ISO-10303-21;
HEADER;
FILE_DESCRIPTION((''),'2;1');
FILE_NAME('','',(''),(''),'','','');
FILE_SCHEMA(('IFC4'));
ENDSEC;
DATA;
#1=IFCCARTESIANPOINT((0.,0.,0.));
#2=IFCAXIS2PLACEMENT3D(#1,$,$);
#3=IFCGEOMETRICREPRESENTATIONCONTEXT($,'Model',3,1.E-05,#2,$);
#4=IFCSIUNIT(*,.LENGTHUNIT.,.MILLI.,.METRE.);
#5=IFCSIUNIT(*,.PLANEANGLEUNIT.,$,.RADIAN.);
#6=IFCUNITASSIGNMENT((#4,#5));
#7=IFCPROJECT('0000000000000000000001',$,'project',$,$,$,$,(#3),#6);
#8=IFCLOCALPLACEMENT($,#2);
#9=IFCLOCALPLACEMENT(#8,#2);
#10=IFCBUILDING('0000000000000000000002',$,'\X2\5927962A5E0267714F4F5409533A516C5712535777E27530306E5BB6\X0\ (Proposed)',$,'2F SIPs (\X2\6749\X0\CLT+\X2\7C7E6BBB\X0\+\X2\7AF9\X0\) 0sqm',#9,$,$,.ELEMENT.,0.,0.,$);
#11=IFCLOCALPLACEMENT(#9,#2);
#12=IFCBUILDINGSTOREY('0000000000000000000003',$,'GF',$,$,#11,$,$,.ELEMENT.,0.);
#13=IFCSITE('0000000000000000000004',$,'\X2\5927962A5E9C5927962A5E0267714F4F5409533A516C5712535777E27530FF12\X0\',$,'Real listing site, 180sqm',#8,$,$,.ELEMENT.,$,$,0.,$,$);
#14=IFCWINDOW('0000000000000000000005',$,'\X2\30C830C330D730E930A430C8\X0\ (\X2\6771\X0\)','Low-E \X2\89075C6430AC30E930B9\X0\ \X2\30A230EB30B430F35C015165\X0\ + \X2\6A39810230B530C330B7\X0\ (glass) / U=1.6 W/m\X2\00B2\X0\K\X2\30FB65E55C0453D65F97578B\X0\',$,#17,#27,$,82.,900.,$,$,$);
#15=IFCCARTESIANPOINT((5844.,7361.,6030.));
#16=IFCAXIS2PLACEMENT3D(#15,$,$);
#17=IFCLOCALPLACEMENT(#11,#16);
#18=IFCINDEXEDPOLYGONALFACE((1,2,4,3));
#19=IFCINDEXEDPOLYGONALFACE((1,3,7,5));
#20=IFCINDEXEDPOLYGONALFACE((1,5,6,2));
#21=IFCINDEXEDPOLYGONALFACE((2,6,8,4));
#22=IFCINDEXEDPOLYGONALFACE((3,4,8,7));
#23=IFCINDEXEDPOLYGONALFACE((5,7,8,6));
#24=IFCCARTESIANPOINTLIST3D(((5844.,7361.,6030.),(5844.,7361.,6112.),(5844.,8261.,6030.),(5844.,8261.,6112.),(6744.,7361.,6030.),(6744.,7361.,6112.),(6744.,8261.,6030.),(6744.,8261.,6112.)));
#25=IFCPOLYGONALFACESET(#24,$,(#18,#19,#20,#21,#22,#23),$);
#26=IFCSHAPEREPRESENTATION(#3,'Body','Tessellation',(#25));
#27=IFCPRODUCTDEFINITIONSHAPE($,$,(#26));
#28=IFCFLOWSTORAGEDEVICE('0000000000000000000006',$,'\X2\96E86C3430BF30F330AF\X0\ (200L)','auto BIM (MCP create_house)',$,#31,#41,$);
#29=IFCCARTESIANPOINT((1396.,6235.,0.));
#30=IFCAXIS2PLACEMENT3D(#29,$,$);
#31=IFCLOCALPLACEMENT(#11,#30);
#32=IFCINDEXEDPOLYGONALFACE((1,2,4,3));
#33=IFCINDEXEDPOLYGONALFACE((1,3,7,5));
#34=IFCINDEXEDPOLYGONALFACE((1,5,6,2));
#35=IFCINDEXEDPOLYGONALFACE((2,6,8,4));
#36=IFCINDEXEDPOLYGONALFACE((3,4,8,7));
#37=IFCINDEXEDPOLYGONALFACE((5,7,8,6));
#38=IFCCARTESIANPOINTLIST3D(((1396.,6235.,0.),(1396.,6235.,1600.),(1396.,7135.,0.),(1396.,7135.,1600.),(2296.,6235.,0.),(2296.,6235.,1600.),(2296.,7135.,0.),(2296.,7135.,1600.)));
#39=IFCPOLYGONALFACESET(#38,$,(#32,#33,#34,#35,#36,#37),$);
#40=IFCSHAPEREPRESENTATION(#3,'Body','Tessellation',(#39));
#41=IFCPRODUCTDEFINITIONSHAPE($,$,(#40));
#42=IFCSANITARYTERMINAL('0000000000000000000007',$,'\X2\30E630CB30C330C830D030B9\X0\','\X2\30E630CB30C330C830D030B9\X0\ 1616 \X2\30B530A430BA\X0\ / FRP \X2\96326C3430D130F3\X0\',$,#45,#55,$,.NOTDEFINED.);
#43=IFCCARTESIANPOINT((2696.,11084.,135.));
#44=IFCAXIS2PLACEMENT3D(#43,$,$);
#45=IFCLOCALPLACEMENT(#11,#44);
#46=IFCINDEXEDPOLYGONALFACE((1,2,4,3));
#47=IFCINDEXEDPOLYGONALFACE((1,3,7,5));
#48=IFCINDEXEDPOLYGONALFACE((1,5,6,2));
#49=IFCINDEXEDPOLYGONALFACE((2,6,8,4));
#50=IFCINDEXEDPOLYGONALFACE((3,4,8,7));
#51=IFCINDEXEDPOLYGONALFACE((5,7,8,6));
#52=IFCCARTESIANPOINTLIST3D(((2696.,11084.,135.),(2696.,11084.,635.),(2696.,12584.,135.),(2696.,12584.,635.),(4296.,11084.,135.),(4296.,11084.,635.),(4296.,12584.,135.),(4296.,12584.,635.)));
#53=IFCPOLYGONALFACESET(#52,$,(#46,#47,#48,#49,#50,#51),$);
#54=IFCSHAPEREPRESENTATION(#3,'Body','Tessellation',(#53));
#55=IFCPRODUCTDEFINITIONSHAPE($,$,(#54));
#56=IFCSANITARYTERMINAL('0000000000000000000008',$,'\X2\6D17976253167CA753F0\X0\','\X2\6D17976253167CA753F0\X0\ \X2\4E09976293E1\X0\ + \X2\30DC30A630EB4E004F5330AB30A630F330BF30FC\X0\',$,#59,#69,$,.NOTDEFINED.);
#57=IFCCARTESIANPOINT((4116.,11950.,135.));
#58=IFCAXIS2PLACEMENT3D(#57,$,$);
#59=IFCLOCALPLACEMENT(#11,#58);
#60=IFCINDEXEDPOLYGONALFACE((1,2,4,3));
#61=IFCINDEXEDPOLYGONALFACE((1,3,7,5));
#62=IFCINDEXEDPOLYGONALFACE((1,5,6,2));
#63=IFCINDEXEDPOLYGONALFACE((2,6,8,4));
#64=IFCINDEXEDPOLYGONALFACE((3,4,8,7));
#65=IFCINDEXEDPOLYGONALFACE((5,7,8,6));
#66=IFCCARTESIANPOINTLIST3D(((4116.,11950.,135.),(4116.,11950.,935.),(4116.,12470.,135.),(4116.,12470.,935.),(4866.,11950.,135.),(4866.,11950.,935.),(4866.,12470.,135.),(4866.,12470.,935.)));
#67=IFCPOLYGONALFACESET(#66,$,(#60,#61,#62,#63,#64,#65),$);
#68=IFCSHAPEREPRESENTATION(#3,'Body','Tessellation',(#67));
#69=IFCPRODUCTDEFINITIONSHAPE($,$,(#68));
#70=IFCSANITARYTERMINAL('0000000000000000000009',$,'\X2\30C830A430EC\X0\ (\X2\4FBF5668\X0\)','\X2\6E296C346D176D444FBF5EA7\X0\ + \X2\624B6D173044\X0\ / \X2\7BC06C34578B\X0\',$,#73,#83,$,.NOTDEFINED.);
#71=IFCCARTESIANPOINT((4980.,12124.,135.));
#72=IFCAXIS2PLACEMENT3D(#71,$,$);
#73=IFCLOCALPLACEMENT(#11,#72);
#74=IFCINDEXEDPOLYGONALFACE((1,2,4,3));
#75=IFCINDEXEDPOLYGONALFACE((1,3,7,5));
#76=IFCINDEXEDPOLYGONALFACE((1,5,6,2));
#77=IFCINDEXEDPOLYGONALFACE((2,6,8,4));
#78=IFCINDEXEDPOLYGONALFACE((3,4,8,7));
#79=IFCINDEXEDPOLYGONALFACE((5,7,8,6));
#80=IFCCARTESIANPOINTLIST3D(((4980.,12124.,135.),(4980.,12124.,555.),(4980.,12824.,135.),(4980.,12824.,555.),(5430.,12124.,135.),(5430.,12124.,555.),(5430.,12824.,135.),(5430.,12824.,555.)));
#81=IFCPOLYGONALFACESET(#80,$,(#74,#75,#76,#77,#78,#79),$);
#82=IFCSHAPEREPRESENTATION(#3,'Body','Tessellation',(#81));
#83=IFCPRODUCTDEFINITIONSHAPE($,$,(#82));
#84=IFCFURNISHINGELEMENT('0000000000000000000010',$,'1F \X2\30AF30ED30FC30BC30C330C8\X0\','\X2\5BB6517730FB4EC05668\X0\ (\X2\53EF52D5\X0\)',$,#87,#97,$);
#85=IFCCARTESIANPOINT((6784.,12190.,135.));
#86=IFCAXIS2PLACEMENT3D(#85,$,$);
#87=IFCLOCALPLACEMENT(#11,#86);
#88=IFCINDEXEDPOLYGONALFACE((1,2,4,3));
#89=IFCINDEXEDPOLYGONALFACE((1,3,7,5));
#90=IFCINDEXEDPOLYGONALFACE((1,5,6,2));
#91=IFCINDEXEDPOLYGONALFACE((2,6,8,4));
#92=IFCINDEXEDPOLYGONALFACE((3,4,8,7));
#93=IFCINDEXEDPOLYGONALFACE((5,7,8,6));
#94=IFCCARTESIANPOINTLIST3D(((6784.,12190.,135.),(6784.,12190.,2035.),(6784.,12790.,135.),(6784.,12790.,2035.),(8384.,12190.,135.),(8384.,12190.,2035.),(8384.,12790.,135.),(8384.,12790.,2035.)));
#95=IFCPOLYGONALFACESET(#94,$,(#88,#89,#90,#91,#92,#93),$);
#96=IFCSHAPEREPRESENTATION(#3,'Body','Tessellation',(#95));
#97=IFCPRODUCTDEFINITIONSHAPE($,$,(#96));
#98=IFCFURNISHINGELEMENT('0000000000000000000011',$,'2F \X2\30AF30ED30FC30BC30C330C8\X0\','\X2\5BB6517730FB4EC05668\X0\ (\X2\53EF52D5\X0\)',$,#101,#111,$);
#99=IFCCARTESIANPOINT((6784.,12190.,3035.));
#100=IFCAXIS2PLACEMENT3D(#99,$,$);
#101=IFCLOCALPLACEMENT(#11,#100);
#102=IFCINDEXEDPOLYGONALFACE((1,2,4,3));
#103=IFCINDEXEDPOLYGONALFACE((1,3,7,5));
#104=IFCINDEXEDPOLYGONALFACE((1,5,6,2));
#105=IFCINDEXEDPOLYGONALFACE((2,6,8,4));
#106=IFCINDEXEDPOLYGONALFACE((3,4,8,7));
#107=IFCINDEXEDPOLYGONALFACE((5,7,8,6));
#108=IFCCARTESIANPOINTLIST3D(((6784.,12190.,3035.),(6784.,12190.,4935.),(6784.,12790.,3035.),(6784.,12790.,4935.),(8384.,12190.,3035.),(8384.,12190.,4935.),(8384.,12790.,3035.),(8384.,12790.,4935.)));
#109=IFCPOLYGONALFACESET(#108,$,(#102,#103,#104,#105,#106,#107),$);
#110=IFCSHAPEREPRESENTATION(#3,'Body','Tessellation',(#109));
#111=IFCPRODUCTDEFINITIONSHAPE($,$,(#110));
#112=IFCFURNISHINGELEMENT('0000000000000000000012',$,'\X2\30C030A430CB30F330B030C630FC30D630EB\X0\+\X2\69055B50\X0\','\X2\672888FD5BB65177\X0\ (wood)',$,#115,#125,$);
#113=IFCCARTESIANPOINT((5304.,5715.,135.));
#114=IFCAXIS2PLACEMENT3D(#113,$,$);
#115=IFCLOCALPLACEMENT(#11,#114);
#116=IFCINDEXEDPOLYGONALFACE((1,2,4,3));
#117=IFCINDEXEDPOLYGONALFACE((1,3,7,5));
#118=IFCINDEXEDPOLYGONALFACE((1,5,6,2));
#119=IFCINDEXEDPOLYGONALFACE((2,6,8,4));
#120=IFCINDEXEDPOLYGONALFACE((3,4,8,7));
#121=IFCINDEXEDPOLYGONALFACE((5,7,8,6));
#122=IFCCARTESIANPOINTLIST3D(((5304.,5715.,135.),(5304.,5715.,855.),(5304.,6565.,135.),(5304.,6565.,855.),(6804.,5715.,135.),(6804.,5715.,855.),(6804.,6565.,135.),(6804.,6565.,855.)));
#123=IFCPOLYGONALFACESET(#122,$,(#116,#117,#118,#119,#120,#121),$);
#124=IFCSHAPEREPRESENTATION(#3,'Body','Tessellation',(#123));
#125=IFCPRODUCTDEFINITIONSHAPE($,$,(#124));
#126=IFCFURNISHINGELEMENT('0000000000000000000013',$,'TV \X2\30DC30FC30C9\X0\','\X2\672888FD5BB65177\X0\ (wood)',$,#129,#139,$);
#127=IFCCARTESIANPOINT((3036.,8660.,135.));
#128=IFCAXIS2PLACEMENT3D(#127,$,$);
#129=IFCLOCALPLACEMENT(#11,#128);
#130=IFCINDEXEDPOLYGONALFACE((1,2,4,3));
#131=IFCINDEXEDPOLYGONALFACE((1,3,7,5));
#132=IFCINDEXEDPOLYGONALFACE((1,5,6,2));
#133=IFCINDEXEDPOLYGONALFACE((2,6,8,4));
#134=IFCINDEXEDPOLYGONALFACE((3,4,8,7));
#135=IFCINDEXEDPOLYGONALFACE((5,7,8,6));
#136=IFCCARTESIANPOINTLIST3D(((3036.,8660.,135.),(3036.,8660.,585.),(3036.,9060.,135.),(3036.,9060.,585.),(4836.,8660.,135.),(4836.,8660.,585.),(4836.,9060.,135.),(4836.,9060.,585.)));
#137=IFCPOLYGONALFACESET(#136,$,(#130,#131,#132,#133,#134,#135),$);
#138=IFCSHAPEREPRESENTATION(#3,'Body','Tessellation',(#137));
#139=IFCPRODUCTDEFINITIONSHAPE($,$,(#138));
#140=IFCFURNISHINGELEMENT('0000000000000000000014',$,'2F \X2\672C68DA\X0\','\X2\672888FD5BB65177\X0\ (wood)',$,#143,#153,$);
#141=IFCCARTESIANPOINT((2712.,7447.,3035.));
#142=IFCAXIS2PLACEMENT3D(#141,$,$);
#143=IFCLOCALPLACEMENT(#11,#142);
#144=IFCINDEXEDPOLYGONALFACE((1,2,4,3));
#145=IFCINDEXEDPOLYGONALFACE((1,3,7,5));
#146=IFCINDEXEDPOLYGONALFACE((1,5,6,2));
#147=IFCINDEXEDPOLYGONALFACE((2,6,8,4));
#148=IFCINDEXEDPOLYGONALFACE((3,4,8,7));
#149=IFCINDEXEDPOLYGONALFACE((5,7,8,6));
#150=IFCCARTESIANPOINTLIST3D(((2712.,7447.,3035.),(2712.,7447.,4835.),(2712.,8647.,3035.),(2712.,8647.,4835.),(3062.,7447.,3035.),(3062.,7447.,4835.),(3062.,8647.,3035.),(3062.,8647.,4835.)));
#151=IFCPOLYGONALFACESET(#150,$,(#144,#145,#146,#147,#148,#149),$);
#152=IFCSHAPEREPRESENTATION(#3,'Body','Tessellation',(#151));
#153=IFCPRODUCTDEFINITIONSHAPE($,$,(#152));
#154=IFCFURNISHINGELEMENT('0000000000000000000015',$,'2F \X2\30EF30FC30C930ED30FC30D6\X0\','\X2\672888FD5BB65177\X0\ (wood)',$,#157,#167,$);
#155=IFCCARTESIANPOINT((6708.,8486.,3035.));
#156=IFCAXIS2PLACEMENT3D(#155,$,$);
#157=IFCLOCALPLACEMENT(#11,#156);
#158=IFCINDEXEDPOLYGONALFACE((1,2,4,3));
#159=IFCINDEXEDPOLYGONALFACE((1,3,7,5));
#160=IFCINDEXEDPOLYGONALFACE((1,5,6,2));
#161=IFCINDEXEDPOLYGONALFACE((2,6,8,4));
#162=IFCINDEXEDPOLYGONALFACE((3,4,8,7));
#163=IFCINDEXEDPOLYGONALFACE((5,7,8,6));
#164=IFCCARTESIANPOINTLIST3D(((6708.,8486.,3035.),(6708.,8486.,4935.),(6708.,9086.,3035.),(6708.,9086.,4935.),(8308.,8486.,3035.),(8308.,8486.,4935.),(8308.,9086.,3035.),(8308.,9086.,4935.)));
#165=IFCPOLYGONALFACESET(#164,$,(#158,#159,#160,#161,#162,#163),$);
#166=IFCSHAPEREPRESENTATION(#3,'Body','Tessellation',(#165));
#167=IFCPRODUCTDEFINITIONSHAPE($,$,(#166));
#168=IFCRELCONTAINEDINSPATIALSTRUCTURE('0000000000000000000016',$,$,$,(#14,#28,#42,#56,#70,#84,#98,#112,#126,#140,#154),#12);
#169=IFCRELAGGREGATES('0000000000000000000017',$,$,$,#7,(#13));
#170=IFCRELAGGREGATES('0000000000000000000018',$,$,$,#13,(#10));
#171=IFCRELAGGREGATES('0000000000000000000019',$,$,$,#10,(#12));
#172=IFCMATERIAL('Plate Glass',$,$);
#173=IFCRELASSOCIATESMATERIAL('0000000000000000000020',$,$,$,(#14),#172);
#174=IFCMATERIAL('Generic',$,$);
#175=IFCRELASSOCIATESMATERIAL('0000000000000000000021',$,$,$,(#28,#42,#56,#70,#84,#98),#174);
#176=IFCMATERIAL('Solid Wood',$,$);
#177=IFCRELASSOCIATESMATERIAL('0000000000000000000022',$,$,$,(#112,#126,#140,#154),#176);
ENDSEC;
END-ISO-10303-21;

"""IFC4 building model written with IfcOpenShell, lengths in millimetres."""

from ifc_helpers import new_model, si_unit, frame, frame_2d, origin, place, context, project, spatial, rectangle, extrude, material, element, save


model = new_model("IFC4")

# Units and contexts
model_context = context("Model", 3, precision=1e-05, world=origin())
ifc_project = project(units=[si_unit("LENGTHUNIT", "METRE", prefix="MILLI"), si_unit("PLANEANGLEUNIT", "RADIAN")], contexts=[model_context])

# Site, building, storey
site_placement = place(None, origin())
site = spatial("IfcSite", under=ifc_project, at=site_placement, Name="大阪府大阪市東住吉区公園南矢田２", ObjectType="Real listing site, 180sqm", CompositionType="ELEMENT", RefElevation=0.0)
building_placement = place(site_placement, origin())
building = spatial("IfcBuilding", under=site, at=building_placement, Name="大阪市東住吉区公園南矢田の家 (Proposed)", ObjectType="2F SIPs (杉CLT+籾殻+竹) 0sqm", CompositionType="ELEMENT", ElevationOfRefHeight=0.0, ElevationOfTerrain=0.0)
storey_placement = place(building_placement, origin())
storey = spatial("IfcBuildingStorey", under=building, at=storey_placement, Name="GF", CompositionType="ELEMENT", Elevation=0.0)

# Shared definitions
ifc_material_1 = material(Name="Solid Wood")
ifc_material_2 = material(Name="Plate Glass")

# Window
window_1_placement = place(storey_placement, frame((5844.0, 7361.0, 6030.0)))
element("IfcWindow", 1, at=window_1_placement, inside=storey, material=ifc_material_2, Name="トップライト (東)", Description="Low-E 複層ガラス アルゴン封入 + 樹脂サッシ (glass) / U=1.6 W/m²K・日射取得型", OverallHeight=82.0, OverallWidth=900.0, context=model_context, shape_type="SweptSolid", body=[
    extrude(rectangle(XDim=900.0, YDim=900.0, at=frame_2d((450.0, 450.0))), frame((5844.0, 7361.0, 6030.0)), (0.0, 0.0, 1.0), 82.0),
])

# Flow storage device
ifc_material_3 = material(Name="Generic")
flow_storage_device_placement = place(storey_placement, frame((1396.0, 6235.0, 0.0)))
element("IfcFlowStorageDevice", 2, at=flow_storage_device_placement, inside=storey, material=ifc_material_3, Name="雨水タンク (200L)", Description="auto BIM (MCP create_house)", context=model_context, shape_type="SweptSolid", body=[
    extrude(rectangle(XDim=900.0, YDim=900.0, at=frame_2d((450.0, 450.0))), frame((1396.0, 6235.0, 0.0)), (0.0, 0.0, 1.0), 1600.0),
])

# Sanitary terminals
sanitary_terminal_1_placement = place(storey_placement, frame((2696.0, 11084.0, 135.0)))
element("IfcSanitaryTerminal", 3, at=sanitary_terminal_1_placement, inside=storey, material=ifc_material_3, Name="ユニットバス", Description="ユニットバス 1616 サイズ / FRP 防水パン", PredefinedType="NOTDEFINED", context=model_context, shape_type="SweptSolid", body=[
    extrude(rectangle(XDim=1600.0, YDim=1500.0, at=frame_2d((800.0, 750.0))), frame((2696.0, 11084.0, 135.0)), (0.0, 0.0, 1.0), 500.0),
])
sanitary_terminal_2_placement = place(storey_placement, frame((4116.0, 11950.0, 135.0)))
element("IfcSanitaryTerminal", 4, at=sanitary_terminal_2_placement, inside=storey, material=ifc_material_3, Name="洗面化粧台", Description="洗面化粧台 三面鏡 + ボウル一体カウンター", PredefinedType="NOTDEFINED", context=model_context, shape_type="SweptSolid", body=[
    extrude(rectangle(XDim=750.0, YDim=520.0, at=frame_2d((375.0, 260.0))), frame((4116.0, 11950.0, 135.0)), (0.0, 0.0, 1.0), 800.0),
])
sanitary_terminal_3_placement = place(storey_placement, frame((4980.0, 12124.0, 135.0)))
element("IfcSanitaryTerminal", 5, at=sanitary_terminal_3_placement, inside=storey, material=ifc_material_3, Name="トイレ (便器)", Description="温水洗浄便座 + 手洗い / 節水型", PredefinedType="NOTDEFINED", context=model_context, shape_type="SweptSolid", body=[
    extrude(rectangle(XDim=450.0, YDim=700.0, at=frame_2d((225.0, 350.0))), frame((4980.0, 12124.0, 135.0)), (0.0, 0.0, 1.0), 420.0),
])

# Furnishing elements
furnishing_1_placement = place(storey_placement, frame((6784.0, 12190.0, 135.0)))
element("IfcFurnishingElement", 6, at=furnishing_1_placement, inside=storey, material=ifc_material_3, Name="1F クローゼット", Description="家具・什器 (可動)", context=model_context, shape_type="SweptSolid", body=[
    extrude(rectangle(XDim=1600.0, YDim=600.0, at=frame_2d((800.0, 300.0))), frame((6784.0, 12190.0, 135.0)), (0.0, 0.0, 1.0), 1900.0),
])
furnishing_2_placement = place(storey_placement, frame((6784.0, 12190.0, 3035.0)))
element("IfcFurnishingElement", 7, at=furnishing_2_placement, inside=storey, material=ifc_material_3, Name="2F クローゼット", Description="家具・什器 (可動)", context=model_context, shape_type="SweptSolid", body=[
    extrude(rectangle(XDim=1600.0, YDim=600.0, at=frame_2d((800.0, 300.0))), frame((6784.0, 12190.0, 3035.0)), (0.0, 0.0, 1.0), 1900.0),
])
furnishing_3_placement = place(storey_placement, frame((5304.0, 5715.0, 135.0)))
element("IfcFurnishingElement", 8, at=furnishing_3_placement, inside=storey, material=ifc_material_1, Name="ダイニングテーブル+椅子", Description="木製家具 (wood)", context=model_context, shape_type="SweptSolid", body=[
    extrude(rectangle(XDim=1500.0, YDim=850.0, at=frame_2d((750.0, 425.0))), frame((5304.0, 5715.0, 135.0)), (0.0, 0.0, 1.0), 720.0),
])
furnishing_4_placement = place(storey_placement, frame((3036.0, 8660.0, 135.0)))
element("IfcFurnishingElement", 9, at=furnishing_4_placement, inside=storey, material=ifc_material_1, Name="TV ボード", Description="木製家具 (wood)", context=model_context, shape_type="SweptSolid", body=[
    extrude(rectangle(XDim=1800.0, YDim=400.0, at=frame_2d((900.0, 200.0))), frame((3036.0, 8660.0, 135.0)), (0.0, 0.0, 1.0), 450.0),
])
furnishing_5_placement = place(storey_placement, frame((2712.0, 7447.0, 3035.0)))
element("IfcFurnishingElement", 10, at=furnishing_5_placement, inside=storey, material=ifc_material_1, Name="2F 本棚", Description="木製家具 (wood)", context=model_context, shape_type="SweptSolid", body=[
    extrude(rectangle(XDim=350.0, YDim=1200.0, at=frame_2d((175.0, 600.0))), frame((2712.0, 7447.0, 3035.0)), (0.0, 0.0, 1.0), 1800.0),
])
furnishing_6_placement = place(storey_placement, frame((6708.0, 8486.0, 3035.0)))
element("IfcFurnishingElement", 11, at=furnishing_6_placement, inside=storey, material=ifc_material_1, Name="2F ワードローブ", Description="木製家具 (wood)", context=model_context, shape_type="SweptSolid", body=[
    extrude(rectangle(XDim=1600.0, YDim=600.0, at=frame_2d((800.0, 300.0))), frame((6708.0, 8486.0, 3035.0)), (0.0, 0.0, 1.0), 1900.0),
])

save(model, "model.ifc")
